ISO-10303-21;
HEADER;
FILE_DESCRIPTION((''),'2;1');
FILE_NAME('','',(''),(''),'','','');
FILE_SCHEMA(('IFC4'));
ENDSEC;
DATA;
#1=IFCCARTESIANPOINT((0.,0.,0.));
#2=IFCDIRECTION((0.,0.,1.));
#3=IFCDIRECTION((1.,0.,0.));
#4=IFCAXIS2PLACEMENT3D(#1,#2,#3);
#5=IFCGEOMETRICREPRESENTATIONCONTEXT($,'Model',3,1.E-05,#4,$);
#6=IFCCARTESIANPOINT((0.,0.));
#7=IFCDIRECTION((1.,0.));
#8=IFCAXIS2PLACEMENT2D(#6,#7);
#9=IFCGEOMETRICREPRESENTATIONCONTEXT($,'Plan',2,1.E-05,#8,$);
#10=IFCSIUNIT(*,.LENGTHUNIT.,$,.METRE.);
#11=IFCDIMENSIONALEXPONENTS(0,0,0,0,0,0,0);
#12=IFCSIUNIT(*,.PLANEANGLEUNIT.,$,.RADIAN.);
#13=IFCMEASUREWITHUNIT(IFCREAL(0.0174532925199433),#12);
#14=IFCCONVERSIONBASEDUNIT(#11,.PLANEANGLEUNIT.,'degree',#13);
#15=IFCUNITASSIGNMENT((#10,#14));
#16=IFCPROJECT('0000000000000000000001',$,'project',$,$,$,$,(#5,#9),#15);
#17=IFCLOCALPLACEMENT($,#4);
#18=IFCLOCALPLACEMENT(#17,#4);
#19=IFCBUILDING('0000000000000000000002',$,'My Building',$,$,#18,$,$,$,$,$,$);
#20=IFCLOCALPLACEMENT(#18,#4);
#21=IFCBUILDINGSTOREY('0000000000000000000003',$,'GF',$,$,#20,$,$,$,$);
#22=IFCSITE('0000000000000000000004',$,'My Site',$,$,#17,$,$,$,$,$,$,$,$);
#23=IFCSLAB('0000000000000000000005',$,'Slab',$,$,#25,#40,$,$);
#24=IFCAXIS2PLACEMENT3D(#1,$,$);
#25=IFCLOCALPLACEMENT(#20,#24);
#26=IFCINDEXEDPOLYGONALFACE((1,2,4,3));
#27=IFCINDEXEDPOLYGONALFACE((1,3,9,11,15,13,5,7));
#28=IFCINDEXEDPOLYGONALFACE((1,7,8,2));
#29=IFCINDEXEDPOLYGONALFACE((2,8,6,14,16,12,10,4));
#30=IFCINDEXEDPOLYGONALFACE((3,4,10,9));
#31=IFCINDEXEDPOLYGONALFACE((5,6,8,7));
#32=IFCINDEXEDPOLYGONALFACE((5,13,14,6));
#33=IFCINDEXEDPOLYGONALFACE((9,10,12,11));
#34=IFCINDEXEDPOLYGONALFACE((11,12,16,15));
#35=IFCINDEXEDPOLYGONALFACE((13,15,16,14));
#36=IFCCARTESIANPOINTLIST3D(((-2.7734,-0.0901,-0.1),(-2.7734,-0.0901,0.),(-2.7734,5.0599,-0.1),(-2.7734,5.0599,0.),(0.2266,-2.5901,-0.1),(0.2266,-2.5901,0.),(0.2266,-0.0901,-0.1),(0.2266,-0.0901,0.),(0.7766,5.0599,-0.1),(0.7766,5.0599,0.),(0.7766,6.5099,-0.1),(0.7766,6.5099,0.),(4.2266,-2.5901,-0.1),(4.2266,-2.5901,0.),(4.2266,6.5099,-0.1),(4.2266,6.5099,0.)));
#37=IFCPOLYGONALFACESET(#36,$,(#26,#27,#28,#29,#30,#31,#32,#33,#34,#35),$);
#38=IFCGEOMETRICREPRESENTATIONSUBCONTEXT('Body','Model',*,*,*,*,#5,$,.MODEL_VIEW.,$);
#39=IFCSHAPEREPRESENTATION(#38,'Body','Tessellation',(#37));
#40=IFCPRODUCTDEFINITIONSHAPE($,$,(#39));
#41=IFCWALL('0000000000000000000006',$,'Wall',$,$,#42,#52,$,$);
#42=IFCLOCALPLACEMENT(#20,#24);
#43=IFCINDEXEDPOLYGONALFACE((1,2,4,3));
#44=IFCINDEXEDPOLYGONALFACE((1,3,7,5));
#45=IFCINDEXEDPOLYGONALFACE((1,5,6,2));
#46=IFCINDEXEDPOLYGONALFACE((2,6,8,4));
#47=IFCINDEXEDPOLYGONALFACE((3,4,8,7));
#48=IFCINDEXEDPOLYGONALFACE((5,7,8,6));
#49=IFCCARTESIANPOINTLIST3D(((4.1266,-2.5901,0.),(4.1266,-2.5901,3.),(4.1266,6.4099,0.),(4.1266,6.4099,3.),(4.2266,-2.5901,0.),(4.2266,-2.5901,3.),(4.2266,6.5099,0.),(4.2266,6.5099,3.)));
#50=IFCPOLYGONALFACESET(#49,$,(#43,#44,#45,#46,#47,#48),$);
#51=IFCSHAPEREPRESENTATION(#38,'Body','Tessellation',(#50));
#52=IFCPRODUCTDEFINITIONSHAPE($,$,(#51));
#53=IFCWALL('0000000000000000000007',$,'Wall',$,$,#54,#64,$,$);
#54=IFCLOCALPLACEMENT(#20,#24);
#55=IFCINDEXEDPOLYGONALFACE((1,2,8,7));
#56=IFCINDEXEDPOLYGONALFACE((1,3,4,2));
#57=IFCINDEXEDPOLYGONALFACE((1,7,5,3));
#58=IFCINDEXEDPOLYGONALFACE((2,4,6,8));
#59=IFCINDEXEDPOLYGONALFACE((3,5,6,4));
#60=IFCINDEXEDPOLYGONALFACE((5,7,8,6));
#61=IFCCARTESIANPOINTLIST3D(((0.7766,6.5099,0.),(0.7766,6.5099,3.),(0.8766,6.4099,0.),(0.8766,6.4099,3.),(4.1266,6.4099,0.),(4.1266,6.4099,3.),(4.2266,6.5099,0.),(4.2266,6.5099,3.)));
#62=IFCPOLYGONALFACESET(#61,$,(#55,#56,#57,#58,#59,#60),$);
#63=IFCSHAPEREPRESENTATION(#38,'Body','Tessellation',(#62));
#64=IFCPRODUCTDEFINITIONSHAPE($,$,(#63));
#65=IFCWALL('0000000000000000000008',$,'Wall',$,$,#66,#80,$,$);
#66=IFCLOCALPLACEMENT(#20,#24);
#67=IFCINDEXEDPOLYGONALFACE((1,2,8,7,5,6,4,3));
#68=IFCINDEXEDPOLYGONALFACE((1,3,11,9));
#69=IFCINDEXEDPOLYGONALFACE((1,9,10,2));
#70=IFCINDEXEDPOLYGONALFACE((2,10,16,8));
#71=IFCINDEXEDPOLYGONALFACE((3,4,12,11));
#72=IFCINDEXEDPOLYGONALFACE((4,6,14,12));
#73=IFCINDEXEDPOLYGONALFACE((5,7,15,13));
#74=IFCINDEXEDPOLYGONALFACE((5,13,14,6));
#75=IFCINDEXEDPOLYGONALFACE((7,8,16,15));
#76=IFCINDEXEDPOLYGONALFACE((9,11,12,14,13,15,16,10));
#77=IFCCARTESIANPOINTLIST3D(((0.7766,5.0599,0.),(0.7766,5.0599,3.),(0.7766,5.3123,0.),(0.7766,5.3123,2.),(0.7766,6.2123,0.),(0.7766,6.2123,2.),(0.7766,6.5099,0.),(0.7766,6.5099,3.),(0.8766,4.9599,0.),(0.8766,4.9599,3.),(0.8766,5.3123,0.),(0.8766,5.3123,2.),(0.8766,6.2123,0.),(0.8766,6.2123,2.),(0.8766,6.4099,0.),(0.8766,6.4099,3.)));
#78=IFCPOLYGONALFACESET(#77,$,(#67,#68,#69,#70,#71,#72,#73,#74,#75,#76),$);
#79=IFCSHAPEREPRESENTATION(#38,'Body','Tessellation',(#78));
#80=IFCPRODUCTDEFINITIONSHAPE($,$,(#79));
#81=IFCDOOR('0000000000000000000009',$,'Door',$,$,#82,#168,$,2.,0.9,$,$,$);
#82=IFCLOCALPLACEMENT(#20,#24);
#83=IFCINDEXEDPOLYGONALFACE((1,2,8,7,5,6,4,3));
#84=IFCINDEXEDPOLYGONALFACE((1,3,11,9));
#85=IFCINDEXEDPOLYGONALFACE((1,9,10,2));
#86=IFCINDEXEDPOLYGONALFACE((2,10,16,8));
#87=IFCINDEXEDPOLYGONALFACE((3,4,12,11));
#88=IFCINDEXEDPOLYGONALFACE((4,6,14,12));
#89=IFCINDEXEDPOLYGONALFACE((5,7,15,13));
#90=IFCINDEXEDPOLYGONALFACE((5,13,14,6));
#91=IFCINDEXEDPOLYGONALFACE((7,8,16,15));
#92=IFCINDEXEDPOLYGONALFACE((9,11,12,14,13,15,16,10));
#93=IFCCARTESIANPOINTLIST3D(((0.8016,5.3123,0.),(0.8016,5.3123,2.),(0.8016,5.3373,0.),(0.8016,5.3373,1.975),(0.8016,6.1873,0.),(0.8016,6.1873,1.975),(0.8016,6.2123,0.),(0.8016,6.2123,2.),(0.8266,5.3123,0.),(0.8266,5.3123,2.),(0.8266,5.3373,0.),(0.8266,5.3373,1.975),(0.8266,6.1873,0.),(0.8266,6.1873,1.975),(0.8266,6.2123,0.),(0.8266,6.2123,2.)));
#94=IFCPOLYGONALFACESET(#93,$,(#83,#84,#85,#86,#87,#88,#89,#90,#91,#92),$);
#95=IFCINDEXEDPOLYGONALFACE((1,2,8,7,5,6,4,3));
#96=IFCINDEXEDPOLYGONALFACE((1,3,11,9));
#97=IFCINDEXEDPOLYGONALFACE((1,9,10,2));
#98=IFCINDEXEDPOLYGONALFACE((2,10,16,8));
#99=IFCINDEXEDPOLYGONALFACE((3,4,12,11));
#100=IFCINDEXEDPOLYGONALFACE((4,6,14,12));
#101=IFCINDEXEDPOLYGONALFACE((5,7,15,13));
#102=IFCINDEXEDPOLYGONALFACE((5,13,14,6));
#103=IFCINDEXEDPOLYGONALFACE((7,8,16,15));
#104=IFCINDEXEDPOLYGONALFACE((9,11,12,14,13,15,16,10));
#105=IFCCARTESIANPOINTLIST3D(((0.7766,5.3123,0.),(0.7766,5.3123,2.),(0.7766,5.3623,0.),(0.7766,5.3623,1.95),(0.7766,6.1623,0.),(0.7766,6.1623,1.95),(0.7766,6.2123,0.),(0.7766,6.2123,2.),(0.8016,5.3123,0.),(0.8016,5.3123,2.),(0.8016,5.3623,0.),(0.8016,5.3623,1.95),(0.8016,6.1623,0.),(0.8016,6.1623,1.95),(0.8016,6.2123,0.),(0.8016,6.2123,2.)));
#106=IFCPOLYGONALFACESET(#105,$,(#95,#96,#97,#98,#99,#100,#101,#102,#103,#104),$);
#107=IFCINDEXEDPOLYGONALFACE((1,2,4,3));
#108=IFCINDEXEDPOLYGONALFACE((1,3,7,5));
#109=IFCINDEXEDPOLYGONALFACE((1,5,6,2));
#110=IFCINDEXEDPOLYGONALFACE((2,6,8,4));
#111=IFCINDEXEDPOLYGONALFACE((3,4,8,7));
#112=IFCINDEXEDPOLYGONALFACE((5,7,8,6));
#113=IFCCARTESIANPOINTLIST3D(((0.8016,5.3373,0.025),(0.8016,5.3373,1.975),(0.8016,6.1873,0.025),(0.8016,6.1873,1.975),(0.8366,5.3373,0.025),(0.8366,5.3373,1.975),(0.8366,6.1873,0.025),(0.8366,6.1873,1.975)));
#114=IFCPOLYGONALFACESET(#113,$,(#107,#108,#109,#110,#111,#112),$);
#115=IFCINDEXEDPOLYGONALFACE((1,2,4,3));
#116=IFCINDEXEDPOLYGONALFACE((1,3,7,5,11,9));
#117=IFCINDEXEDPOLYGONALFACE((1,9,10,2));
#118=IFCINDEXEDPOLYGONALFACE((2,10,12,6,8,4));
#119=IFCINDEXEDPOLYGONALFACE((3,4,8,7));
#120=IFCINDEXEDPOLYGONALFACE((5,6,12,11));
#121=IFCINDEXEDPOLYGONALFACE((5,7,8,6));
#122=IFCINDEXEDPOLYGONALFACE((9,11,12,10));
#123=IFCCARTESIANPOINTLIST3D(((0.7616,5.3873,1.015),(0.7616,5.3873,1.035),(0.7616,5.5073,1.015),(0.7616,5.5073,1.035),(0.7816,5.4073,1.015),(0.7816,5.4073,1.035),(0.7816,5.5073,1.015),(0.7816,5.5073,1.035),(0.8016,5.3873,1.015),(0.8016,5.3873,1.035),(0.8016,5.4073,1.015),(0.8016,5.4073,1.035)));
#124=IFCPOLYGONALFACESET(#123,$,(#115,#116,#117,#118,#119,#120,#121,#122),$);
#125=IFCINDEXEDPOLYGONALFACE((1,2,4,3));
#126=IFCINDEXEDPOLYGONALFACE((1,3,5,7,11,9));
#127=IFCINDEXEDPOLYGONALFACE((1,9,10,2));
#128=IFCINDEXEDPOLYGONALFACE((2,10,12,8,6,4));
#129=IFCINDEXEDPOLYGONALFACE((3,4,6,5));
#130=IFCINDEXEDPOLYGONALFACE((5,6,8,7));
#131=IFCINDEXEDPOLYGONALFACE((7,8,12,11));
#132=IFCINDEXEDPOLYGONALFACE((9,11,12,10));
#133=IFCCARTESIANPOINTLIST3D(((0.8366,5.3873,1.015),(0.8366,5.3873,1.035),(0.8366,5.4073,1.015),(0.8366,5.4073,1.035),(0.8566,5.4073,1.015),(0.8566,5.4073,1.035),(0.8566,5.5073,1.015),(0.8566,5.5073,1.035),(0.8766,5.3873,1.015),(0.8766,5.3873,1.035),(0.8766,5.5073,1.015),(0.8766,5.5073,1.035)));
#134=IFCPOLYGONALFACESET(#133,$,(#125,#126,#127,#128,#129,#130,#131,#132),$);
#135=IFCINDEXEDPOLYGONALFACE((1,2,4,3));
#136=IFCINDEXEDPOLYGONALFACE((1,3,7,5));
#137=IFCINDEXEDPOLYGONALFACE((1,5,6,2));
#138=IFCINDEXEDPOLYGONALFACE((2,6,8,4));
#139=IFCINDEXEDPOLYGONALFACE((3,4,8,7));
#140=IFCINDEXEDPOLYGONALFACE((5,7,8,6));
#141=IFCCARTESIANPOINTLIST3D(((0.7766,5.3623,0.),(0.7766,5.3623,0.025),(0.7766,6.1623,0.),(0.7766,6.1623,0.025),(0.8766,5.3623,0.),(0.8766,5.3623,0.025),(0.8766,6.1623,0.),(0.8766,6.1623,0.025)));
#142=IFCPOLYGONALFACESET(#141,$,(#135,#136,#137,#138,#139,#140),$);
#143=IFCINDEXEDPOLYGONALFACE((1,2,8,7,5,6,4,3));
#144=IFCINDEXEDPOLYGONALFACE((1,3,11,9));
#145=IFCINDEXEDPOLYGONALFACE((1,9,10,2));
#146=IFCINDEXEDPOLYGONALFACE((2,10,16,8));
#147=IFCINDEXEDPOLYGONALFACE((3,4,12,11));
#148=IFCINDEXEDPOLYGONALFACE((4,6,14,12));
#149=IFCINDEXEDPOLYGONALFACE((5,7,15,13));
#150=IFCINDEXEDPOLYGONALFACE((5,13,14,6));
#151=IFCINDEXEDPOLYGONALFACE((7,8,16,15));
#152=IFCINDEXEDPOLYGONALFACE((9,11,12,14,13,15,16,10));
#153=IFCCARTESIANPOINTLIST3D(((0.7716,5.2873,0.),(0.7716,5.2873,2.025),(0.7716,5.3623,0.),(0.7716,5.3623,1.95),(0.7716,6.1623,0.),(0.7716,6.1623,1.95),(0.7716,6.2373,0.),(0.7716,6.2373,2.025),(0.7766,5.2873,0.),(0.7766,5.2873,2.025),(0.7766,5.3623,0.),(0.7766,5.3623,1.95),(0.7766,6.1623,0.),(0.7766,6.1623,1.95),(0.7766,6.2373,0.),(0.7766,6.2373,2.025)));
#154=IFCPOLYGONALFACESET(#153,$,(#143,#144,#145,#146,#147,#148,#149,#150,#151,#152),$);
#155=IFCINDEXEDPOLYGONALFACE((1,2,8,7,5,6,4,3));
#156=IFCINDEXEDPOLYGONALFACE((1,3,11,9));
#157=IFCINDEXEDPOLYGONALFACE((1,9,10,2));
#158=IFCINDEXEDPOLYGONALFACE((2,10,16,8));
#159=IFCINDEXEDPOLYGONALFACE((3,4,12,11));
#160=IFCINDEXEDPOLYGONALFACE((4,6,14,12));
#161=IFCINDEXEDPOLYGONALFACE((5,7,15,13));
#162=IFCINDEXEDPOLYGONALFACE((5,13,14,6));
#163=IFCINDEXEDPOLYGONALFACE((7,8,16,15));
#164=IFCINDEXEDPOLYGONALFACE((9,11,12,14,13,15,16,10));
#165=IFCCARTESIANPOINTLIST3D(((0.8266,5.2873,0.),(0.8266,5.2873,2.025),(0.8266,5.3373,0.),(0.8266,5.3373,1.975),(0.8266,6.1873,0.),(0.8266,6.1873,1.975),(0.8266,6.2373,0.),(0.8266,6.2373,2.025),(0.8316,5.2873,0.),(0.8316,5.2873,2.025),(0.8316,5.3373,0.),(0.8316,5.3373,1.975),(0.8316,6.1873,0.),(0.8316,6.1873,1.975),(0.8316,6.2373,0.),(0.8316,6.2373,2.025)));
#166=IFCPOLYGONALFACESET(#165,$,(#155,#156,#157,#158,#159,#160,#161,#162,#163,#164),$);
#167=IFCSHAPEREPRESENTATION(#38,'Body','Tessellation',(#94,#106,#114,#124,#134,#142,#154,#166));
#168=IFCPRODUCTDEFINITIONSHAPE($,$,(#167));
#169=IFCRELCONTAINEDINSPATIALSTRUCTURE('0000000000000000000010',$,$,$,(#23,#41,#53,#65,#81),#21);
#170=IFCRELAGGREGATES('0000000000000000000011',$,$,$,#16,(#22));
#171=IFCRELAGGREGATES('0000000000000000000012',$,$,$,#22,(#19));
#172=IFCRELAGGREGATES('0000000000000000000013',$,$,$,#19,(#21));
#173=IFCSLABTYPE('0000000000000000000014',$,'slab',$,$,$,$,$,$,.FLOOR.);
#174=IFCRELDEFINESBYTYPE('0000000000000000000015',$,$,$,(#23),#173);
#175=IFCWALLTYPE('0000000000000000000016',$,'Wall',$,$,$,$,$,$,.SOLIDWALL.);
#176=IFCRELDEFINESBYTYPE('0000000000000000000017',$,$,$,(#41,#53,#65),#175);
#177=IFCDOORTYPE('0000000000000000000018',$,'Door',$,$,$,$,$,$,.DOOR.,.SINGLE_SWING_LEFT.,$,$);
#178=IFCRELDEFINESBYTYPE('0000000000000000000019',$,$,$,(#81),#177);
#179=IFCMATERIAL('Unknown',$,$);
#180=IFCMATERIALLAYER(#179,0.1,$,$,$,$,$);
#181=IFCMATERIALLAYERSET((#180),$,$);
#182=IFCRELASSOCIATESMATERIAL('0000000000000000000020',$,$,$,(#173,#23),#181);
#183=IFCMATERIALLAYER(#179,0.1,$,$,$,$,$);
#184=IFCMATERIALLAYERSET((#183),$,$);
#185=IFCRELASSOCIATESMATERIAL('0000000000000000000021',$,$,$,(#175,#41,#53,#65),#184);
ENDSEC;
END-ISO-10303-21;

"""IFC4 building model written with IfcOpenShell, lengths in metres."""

from ifc_helpers import new_model, entity, si_unit, converted_unit, frame, origin_with_axes, origin_2d_with_axis, place, context, subcontext, project, spatial, line, indexed_curve, outline, extrude, shape, source, transform, mapped, material, layer, layer_set, layer_usage, type_object, type_shapes, element, fill, save


model = new_model("IFC4")

# Units and contexts
model_context = context("Model", 3, precision=1e-05, world=origin_with_axes())
plan_context = context("Plan", 2, precision=1e-05, world=origin_2d_with_axis())
body_context_1 = subcontext(model_context, "Body", "Model", "MODEL_VIEW")
body_context_2 = subcontext(plan_context, "Body", "Plan", "PLAN_VIEW")
ifc_project = project(units=[si_unit("LENGTHUNIT", "METRE"), converted_unit("PLANEANGLEUNIT", "degree", entity("IfcReal", 0.0174532925199433), si_unit("PLANEANGLEUNIT", "RADIAN"), dimensions=[0, 0, 0, 0, 0, 0, 0])], contexts=[model_context, plan_context])

# Site, building, storey
site_placement = place(None, origin_with_axes())
site = spatial("IfcSite", under=ifc_project, at=site_placement, Name="My Site")
building_placement = place(site_placement, origin_with_axes())
building = spatial("IfcBuilding", under=site, at=building_placement, Name="My Building")
storey_placement = place(building_placement, origin_with_axes())
storey = spatial("IfcBuildingStorey", under=building, at=storey_placement, Name="GF")

# Slab
ifc_material = material(Name="Unknown")
ifc_layer_1 = layer(ifc_material, 0.1)
ifc_layer_set_1 = layer_set([ifc_layer_1])
ifc_layer_usage_1 = layer_usage(ifc_layer_set_1, "AXIS3", "POSITIVE", -0.1)
slab_type = type_object("IfcSlabType", Name="slab", PredefinedType="FLOOR", material=ifc_layer_set_1)
slab_placement = place(storey_placement, frame((4.2266, -2.5901, 0.0), z_axis=(0.0, 0.0, 1.0), x_axis=(1.0, 0.0, 0.0)))
element("IfcSlab", 1, at=slab_placement, inside=storey, type_object=slab_type, material=ifc_layer_usage_1, Name="Slab", context=body_context_1, shape_type="SweptSolid", body=[
    extrude(outline(indexed_curve([(0.0, 0.0), (0.0, 9.1), (-3.45, 9.1), (-3.45, 7.65), (-7.0, 7.65), (-7.0, 2.5), (-4.0, 2.5), (-4.0, 0.0), (0.0, 0.0)])), frame((0.0, 0.0, -0.1), z_axis=(0.0, 0.0, 1.0), x_axis=(1.0, 0.0, 0.0)), (0.0, 0.0, 1.0), 0.1),
])

# Shared definitions
ifc_layer_2 = layer(ifc_material, 0.1)
ifc_layer_set_2 = layer_set([ifc_layer_2])
wall_type = type_object("IfcWallType", Name="Wall", PredefinedType="SOLIDWALL", material=ifc_layer_set_2)
shared_shape_1 = source(origin_with_axes(), body_context_1, "Body", "SweptSolid", [
    extrude(outline(indexed_curve([(0.0, 0.0), (0.9, 0.0), (0.9, 2.0), (0.0, 2.0)], segments=[line(1, 2, 3, 4, 1)])), frame((0.0, -0.6, 0.0), z_axis=(0.0, -1.0, 0.0), x_axis=(1.0, 0.0, 0.0)), (0.0, 0.0, -1.0), 1.2),
])
door_type = type_object("IfcDoorType", Name="Door", OperationType="SINGLE_SWING_LEFT", PredefinedType="DOOR")
shared_shape_2 = source(origin_with_axes(), body_context_1, "Body", "SweptSolid", [
    extrude(outline(indexed_curve([(0.0, 0.0), (0.0, 2.0), (0.9, 2.0), (0.9, 0.0), (0.875, 0.0), (0.875, 1.975), (0.025, 1.975), (0.025, 0.0)], segments=[line(1, 2, 3, 4, 5, 6, 7, 8, 1)])), frame((0.0, 0.025, 0.0), z_axis=(0.0, -1.0, 0.0), x_axis=(1.0, 0.0, 0.0)), (0.0, 0.0, -1.0), 0.025),
    extrude(outline(indexed_curve([(0.0, 0.0), (0.0, 2.0), (0.9, 2.0), (0.9, 0.0), (0.85, 0.0), (0.85, 1.95), (0.05, 1.95), (0.05, 0.0)], segments=[line(1, 2, 3, 4, 5, 6, 7, 8, 1)])), frame((0.0, 0.0, 0.0), z_axis=(0.0, -1.0, 0.0), x_axis=(1.0, 0.0, 0.0)), (0.0, 0.0, -1.0), 0.025),
    extrude(outline(indexed_curve([(0.0, 0.0), (0.85, 0.0), (0.85, 0.035), (0.0, 0.035)], segments=[line(1, 2, 3, 4, 1)])), frame((0.025, 0.025, 0.025), z_axis=(0.0, 0.0, 1.0), x_axis=(1.0, 0.0, 0.0)), (0.0, 0.0, 1.0), 1.95),
    extrude(outline(indexed_curve([(0.0, 0.0), (0.0, -0.04), (-0.12, -0.04), (-0.12, -0.02), (-0.02, -0.02), (-0.02, 0.0)], segments=[line(1, 2, 3, 4, 5, 6, 1)])), frame((0.825, 0.025, 1.015), z_axis=(0.0, 0.0, 1.0), x_axis=(1.0, 0.0, 0.0)), (0.0, 0.0, 1.0), 0.02),
    extrude(outline(indexed_curve([(0.0, 0.0), (0.0, 0.04), (-0.12, 0.04), (-0.12, 0.02), (-0.02, 0.02), (-0.02, 0.0)], segments=[line(1, 2, 3, 4, 5, 6, 1)])), frame((0.825, 0.06, 1.015), z_axis=(0.0, 0.0, 1.0), x_axis=(1.0, 0.0, 0.0)), (0.0, 0.0, 1.0), 0.02),
    extrude(outline(indexed_curve([(0.0, 0.0), (0.8, 0.0), (0.8, 0.1), (0.0, 0.1)], segments=[line(1, 2, 3, 4, 1)])), frame((0.05, 0.0, 0.0), z_axis=(0.0, 0.0, 1.0), x_axis=(1.0, 0.0, 0.0)), (0.0, 0.0, 1.0), 0.025),
    extrude(outline(indexed_curve([(0.0, 0.0), (0.0, 2.025), (0.95, 2.025), (0.95, 0.0), (0.875, 0.0), (0.875, 1.95), (0.075, 1.95), (0.075, 0.0)], segments=[line(1, 2, 3, 4, 5, 6, 7, 8, 1)])), frame((-0.025, -0.005, 0.0), z_axis=(0.0, -1.0, 0.0), x_axis=(1.0, 0.0, 0.0)), (0.0, 0.0, -1.0), 0.005),
    extrude(outline(indexed_curve([(0.0, 0.0), (0.0, 2.025), (0.95, 2.025), (0.95, 0.0), (0.9, 0.0), (0.9, 1.975), (0.05, 1.975), (0.05, 0.0)], segments=[line(1, 2, 3, 4, 5, 6, 7, 8, 1)])), frame((-0.025, 0.05, 0.0), z_axis=(0.0, -1.0, 0.0), x_axis=(1.0, 0.0, 0.0)), (0.0, 0.0, -1.0), 0.005),
])
shared_shape_3 = source(origin_with_axes(), body_context_2, "Body", "Curve2D", [
    entity("IfcIndexedPolyCurve", entity("IfcCartesianPointList2D", [[0.0, 0.0], [0.0, 0.05], [0.025, 0.05], [0.025, 0.025], [0.05, 0.025], [0.05, 0.0]]), [entity("IfcLineIndex", [1, 2, 3, 4, 5, 6, 1])]),
    entity("IfcIndexedPolyCurve", entity("IfcCartesianPointList2D", [[0.9, 0.0], [0.9, 0.05], [0.875, 0.05], [0.875, 0.025], [0.85, 0.025], [0.85, 0.0]]), [entity("IfcLineIndex", [1, 2, 3, 4, 5, 6, 1])]),
    entity("IfcTrimmedCurve", entity("IfcEllipse", entity("IfcAxis2Placement2D", entity("IfcCartesianPoint", [0.06, 0.05]), entity("IfcDirection", [1.0, 0.0])), 0.815, 0.85), [entity("IfcCartesianPoint", [0.875, 0.05])], [entity("IfcCartesianPoint", [0.06, 0.9])], True, "CARTESIAN"),
    entity("IfcIndexedPolyCurve", entity("IfcCartesianPointList2D", [[0.025, 0.05], [0.06, 0.05], [0.06, 0.9], [0.025, 0.9]]), [entity("IfcLineIndex", [1, 2, 3, 4, 1])]),
])
type_shapes(door_type, [shared_shape_2, shared_shape_3])

# Walls
ifc_layer_usage_2 = layer_usage(ifc_layer_set_2, "AXIS2", "POSITIVE", 0.0)
wall_1_placement = place(storey_placement, frame((4.2266, -2.5901, 0.0), z_axis=(0.0, 0.0, 1.0), x_axis=(0.0, 1.0, 0.0)))
element("IfcWall", 2, at=wall_1_placement, inside=storey, type_object=wall_type, material=ifc_layer_usage_2, Name="Wall", context=body_context_1, shape_type="SweptSolid", body=[
    extrude(outline(indexed_curve([(0.0, 0.0), (0.0, 0.1), (9.0, 0.1), (9.1, 0.0)], segments=[line(1, 2, 3, 4, 1)])), origin_with_axes(), (0.0, 0.0, 1.0), 3.0),
])
ifc_layer_usage_3 = layer_usage(ifc_layer_set_2, "AXIS2", "POSITIVE", 0.0)
wall_2_placement = place(storey_placement, frame((4.2266, 6.5099, 0.0), z_axis=(0.0, 0.0, 1.0), x_axis=(-1.0, 0.0, 0.0)))
element("IfcWall", 3, at=wall_2_placement, inside=storey, type_object=wall_type, material=ifc_layer_usage_3, Name="Wall", context=body_context_1, shape_type="SweptSolid", body=[
    extrude(outline(indexed_curve([(0.0, 0.0), (0.1, 0.1), (3.35, 0.1), (3.45, 0.0)], segments=[line(1, 2, 3, 4, 1)])), origin_with_axes(), (0.0, 0.0, 1.0), 3.0),
])

# Wall, opening, door
ifc_layer_usage_4 = layer_usage(ifc_layer_set_2, "AXIS2", "POSITIVE", 0.0)
wall_3_placement = place(storey_placement, frame((0.7766, 6.5099, 0.0), z_axis=(0.0, 0.0, 1.0), x_axis=(0.0, -1.0, 0.0)))
wall_3 = element("IfcWall", 4, at=wall_3_placement, inside=storey, type_object=wall_type, material=ifc_layer_usage_4, Name="Wall", context=body_context_1, shape_type="SweptSolid", body=[
    extrude(outline(indexed_curve([(0.0, 0.0), (0.1, 0.1), (1.55, 0.1), (1.45, 0.0)], segments=[line(1, 2, 3, 4, 1)])), origin_with_axes(), (0.0, 0.0, 1.0), 3.0),
])
opening_1_placement = place(wall_3_placement, frame((0.2976, 0.0, 0.0), z_axis=(0.0, 0.0, 1.0), x_axis=(1.0, 0.0, 0.0)))
opening_1 = element("IfcOpeningElement", 5, at=opening_1_placement, cuts=wall_3, PredefinedType="OPENING", context=body_context_1, shape_type="MappedRepresentation", body=[
    mapped(shared_shape_1, transform((0.0, 0.0, 0.0), x_axis=(1.0, 0.0, 0.0), y_axis=(0.0, 1.0, 0.0), z_axis=(0.0, 0.0, 1.0), scale=1.0)),
])
door_1_placement = place(opening_1_placement, frame((0.0, 0.0, 0.0), z_axis=(0.0, 0.0, 1.0), x_axis=(1.0, 0.0, 0.0)))
door_1 = element("IfcDoor", 6, at=door_1_placement, inside=storey, type_object=door_type, Name="Door", OverallHeight=2.0, OverallWidth=0.9, shapes=[
    shape(body_context_1, "Body", "MappedRepresentation", [mapped(shared_shape_2, transform((0.0, 0.0, 0.0), x_axis=(1.0, 0.0, 0.0), y_axis=(0.0, 1.0, 0.0), z_axis=(0.0, 0.0, 1.0), scale=1.0))]),
    shape(body_context_2, "Body", "MappedRepresentation", [mapped(shared_shape_3, transform((0.0, 0.0, 0.0), x_axis=(1.0, 0.0, 0.0), y_axis=(0.0, 1.0, 0.0), z_axis=(0.0, 0.0, 1.0), scale=1.0))]),
])
fill(opening_1, door_1)

save(model, "model.ifc")
